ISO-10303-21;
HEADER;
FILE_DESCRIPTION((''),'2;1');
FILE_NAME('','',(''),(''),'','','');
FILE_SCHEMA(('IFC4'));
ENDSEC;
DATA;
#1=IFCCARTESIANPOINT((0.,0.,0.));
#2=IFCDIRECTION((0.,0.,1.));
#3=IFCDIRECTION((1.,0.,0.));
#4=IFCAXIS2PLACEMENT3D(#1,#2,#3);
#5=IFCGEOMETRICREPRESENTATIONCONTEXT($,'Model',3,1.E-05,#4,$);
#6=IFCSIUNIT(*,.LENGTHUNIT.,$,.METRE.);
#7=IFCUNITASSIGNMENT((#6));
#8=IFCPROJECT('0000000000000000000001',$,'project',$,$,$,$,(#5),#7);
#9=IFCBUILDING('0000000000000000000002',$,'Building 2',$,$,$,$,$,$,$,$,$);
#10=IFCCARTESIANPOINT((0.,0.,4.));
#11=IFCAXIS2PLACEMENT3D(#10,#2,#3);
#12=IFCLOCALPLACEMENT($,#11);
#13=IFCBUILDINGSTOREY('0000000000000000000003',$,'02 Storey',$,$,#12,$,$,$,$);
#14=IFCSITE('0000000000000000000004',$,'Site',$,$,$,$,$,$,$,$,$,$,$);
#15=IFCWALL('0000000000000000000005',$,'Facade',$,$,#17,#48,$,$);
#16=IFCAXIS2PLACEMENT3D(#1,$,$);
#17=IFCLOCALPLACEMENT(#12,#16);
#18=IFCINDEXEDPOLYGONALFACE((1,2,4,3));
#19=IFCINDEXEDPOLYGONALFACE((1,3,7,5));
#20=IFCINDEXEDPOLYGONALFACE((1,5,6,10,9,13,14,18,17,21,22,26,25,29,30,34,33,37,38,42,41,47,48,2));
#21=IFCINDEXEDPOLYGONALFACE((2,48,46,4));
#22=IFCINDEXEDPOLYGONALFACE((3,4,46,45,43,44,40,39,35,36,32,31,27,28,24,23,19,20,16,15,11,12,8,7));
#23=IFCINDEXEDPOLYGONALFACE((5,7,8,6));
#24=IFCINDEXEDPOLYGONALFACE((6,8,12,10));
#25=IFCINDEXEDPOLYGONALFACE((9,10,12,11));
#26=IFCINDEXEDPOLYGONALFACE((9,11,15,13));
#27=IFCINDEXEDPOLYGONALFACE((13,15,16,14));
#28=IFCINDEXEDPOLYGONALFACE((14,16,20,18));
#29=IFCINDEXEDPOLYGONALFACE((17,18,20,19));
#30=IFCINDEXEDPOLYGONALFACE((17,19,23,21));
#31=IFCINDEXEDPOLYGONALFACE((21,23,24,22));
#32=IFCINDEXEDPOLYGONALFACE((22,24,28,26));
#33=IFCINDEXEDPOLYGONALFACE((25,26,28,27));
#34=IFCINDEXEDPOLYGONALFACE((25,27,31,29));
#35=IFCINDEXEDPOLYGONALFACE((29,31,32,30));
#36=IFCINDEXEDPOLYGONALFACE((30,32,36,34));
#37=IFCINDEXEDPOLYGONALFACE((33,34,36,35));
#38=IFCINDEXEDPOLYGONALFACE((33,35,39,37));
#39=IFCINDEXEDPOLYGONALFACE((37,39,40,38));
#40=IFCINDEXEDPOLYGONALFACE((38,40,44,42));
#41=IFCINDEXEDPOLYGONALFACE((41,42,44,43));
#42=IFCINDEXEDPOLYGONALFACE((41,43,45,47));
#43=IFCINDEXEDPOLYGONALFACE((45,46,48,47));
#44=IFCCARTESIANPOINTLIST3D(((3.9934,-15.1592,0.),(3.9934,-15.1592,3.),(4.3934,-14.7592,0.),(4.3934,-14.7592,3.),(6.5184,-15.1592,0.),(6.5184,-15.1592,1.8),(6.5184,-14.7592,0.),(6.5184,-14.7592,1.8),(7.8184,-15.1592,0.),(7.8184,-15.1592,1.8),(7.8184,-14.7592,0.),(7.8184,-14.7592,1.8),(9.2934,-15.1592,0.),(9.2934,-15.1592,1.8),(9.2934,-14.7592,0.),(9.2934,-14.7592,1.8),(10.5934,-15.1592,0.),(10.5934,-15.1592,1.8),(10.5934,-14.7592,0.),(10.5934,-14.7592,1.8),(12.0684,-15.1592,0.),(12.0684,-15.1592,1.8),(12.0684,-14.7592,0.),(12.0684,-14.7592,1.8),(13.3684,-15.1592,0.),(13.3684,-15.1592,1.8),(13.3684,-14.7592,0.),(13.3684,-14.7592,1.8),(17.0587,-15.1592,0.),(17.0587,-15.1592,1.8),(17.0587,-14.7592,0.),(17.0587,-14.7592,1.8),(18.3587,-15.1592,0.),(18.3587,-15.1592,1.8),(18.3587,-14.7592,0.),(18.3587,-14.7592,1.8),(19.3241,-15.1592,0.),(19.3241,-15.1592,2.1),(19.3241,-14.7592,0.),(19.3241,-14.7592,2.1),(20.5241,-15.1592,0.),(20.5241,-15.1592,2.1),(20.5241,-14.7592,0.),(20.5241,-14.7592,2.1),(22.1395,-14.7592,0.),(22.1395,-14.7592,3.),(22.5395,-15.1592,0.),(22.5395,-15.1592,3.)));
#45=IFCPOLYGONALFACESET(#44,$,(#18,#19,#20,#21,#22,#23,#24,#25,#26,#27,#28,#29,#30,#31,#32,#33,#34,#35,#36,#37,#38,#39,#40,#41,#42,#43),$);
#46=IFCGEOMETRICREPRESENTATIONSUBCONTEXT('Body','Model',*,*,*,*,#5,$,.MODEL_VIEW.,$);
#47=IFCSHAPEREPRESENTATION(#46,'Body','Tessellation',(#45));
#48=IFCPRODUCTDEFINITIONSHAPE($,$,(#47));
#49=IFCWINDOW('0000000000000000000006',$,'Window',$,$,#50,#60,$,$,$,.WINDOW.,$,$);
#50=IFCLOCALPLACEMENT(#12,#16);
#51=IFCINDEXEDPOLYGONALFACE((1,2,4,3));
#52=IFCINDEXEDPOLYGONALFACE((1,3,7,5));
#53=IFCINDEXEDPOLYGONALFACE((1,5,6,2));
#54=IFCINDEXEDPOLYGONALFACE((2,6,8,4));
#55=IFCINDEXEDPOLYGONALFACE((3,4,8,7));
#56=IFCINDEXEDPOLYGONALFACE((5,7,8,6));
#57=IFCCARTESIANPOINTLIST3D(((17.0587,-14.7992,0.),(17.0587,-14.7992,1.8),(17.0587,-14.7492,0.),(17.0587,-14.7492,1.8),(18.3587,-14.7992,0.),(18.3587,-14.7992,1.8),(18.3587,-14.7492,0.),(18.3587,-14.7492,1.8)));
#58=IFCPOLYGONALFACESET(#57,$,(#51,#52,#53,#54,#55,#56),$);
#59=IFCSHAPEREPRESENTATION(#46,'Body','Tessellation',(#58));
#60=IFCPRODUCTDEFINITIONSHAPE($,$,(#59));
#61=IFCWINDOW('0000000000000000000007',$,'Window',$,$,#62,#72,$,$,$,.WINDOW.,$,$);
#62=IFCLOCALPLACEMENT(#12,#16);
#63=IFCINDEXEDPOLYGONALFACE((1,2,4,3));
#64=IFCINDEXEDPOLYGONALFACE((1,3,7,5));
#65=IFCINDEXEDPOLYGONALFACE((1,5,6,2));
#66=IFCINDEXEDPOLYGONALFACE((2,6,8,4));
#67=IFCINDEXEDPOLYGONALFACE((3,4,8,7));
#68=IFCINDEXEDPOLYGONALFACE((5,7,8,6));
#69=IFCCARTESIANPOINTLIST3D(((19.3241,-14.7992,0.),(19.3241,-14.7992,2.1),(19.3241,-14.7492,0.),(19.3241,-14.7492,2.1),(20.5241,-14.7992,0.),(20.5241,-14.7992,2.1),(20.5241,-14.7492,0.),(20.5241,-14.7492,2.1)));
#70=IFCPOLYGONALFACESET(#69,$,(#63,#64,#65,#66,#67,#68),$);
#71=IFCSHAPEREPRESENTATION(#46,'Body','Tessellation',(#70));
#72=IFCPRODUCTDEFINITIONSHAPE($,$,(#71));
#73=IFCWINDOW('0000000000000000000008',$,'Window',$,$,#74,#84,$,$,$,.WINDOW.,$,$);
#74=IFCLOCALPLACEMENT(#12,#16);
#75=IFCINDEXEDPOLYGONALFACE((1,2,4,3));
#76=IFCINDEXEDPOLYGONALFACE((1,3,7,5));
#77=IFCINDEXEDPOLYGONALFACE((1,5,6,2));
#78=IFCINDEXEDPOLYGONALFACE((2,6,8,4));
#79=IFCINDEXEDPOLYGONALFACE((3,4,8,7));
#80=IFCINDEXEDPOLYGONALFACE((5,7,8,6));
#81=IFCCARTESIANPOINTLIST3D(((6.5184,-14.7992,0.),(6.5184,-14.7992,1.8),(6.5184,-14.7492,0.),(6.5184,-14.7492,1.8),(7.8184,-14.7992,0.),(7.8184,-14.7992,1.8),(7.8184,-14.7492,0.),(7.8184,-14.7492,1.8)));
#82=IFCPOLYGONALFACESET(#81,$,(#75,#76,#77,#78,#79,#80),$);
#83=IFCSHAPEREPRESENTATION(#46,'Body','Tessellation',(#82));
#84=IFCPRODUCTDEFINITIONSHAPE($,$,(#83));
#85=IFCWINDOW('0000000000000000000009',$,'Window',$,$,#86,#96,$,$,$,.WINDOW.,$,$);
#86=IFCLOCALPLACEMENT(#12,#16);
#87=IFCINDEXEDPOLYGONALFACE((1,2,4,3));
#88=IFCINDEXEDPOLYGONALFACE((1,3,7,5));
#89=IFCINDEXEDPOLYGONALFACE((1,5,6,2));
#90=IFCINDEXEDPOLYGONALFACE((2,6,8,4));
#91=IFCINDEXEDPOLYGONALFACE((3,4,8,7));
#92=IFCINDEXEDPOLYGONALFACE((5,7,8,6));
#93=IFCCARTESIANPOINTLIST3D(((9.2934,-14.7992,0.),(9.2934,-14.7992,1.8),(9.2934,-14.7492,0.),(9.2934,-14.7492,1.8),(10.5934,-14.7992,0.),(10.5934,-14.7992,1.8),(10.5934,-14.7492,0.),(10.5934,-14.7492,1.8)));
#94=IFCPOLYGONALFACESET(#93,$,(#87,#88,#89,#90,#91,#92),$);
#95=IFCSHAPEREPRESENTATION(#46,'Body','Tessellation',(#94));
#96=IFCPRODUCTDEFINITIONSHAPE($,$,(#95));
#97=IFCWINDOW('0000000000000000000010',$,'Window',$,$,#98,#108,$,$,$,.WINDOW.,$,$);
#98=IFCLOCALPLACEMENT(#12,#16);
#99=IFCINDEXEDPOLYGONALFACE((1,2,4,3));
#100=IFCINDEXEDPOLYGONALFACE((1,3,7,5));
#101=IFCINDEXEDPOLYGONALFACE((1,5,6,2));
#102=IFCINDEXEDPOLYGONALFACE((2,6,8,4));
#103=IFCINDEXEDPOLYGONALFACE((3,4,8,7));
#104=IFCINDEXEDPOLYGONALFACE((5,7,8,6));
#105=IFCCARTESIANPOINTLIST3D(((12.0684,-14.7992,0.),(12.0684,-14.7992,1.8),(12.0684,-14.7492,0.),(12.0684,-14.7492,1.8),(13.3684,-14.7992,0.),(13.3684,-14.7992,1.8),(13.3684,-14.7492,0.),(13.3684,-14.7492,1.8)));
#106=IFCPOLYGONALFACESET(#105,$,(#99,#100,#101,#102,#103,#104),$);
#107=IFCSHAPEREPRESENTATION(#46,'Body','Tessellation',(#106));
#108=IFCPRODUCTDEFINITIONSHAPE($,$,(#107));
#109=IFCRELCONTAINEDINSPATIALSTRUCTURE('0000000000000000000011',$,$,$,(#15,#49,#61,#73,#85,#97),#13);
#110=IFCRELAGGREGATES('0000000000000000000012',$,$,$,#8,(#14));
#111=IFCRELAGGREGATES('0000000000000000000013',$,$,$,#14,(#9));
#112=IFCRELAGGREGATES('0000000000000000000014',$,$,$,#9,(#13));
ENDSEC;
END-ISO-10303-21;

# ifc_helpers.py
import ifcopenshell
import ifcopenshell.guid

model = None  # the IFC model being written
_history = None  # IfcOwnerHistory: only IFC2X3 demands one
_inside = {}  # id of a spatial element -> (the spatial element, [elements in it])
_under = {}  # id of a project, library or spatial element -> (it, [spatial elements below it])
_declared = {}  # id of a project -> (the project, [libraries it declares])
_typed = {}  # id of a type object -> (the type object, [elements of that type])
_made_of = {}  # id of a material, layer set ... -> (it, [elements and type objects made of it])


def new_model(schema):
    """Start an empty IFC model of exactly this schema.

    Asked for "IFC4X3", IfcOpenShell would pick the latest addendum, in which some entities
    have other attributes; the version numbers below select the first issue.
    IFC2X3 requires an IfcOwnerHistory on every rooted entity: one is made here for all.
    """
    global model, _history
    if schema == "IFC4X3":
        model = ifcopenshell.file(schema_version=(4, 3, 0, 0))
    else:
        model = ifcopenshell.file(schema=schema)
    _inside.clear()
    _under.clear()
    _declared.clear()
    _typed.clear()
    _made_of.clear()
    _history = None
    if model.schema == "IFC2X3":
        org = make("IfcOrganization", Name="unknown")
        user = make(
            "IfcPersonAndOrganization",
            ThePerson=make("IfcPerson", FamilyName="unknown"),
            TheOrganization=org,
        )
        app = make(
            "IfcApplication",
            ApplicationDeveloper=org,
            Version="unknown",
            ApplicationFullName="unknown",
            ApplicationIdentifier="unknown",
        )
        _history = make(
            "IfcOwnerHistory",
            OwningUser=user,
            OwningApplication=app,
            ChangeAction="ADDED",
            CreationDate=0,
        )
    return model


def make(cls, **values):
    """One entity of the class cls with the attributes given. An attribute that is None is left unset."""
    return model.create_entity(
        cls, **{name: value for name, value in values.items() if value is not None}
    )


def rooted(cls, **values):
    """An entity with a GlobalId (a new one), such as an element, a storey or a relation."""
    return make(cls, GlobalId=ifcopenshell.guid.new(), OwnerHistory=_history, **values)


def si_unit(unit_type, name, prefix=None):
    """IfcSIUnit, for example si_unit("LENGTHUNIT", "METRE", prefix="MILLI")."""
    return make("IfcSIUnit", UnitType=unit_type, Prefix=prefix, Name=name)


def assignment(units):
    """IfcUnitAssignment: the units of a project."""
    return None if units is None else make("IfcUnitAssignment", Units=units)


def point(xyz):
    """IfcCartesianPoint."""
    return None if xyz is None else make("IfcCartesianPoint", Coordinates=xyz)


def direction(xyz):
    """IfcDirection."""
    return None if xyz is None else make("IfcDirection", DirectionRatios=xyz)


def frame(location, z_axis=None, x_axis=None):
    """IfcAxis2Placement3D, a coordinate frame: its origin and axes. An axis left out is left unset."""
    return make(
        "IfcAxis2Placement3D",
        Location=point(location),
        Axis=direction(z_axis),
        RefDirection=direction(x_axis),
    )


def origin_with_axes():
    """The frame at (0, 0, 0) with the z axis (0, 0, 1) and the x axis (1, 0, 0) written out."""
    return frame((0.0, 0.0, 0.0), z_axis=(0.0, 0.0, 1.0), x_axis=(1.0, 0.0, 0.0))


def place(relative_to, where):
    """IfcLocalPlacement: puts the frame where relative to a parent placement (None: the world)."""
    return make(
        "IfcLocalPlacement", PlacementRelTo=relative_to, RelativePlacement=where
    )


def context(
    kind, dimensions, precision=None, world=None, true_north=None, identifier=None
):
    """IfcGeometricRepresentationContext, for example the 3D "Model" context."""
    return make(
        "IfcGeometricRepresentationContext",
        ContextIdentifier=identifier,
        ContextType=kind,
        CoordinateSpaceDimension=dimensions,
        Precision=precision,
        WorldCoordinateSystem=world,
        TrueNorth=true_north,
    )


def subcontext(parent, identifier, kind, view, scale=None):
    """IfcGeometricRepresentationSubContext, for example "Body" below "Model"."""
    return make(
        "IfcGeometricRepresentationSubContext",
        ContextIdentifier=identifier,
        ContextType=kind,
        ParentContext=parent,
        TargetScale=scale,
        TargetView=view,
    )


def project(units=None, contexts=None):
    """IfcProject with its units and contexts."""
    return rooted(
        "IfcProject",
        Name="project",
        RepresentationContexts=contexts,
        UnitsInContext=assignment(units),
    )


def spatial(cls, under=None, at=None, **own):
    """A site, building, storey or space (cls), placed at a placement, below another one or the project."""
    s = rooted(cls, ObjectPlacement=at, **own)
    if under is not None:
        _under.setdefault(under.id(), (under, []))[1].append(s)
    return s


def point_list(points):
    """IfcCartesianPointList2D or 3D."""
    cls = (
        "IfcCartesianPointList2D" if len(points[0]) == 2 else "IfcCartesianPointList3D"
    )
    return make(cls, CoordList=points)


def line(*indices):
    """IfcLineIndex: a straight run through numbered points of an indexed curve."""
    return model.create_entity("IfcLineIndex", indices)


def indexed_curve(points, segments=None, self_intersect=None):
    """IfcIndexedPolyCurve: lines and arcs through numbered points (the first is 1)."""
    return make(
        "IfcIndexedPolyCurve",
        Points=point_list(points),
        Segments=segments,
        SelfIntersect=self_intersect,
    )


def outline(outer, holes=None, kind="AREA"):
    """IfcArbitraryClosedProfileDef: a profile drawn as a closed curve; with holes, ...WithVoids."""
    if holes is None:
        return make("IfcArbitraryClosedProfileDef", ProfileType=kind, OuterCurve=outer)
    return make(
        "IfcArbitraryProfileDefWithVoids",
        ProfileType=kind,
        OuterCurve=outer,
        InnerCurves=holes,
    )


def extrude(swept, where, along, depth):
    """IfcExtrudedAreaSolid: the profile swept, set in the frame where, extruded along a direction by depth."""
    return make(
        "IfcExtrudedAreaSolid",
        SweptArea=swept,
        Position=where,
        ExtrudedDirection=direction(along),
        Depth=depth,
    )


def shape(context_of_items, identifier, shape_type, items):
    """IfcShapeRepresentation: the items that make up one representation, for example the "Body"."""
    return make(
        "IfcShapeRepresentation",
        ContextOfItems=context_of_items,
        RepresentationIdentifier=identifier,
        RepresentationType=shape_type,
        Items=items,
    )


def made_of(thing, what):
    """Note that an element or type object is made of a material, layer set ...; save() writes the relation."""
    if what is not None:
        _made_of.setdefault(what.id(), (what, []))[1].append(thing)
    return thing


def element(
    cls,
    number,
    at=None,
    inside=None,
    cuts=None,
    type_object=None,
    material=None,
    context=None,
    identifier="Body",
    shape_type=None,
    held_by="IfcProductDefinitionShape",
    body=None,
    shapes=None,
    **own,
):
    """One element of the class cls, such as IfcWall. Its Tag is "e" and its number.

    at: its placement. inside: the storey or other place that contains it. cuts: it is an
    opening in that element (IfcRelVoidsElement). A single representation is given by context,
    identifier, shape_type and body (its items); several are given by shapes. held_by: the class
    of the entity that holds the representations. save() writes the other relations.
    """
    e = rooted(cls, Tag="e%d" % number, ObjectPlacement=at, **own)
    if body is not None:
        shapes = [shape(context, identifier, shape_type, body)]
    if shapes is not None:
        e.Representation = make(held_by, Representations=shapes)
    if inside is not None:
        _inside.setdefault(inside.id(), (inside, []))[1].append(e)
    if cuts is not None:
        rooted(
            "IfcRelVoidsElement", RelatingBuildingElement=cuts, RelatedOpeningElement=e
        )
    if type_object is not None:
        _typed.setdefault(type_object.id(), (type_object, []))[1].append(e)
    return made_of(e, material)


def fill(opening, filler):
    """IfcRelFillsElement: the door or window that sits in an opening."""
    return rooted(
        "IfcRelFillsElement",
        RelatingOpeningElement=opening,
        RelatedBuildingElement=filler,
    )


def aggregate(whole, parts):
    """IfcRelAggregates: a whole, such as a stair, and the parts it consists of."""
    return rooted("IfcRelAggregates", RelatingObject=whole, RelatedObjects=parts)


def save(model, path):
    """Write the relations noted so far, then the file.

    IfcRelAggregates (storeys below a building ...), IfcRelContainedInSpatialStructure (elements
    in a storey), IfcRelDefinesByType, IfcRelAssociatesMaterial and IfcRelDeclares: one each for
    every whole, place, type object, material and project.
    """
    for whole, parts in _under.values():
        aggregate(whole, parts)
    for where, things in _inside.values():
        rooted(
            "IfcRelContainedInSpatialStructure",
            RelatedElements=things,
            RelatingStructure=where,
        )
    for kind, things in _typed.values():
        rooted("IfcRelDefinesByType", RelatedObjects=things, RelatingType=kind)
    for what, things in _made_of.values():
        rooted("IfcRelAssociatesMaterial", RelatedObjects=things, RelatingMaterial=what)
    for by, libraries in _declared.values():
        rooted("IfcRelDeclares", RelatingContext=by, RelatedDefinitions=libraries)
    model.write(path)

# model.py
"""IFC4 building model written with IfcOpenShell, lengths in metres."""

from ifc_helpers import new_model, si_unit, frame, origin_with_axes, place, context, subcontext, project, spatial, line, indexed_curve, outline, extrude, element, fill, save


model = new_model("IFC4")

# Units and contexts
model_context = context("Model", 3, precision=1e-05, world=origin_with_axes())
body_context = subcontext(model_context, "Body", "Model", "MODEL_VIEW")
ifc_project = project(units=[si_unit("LENGTHUNIT", "METRE")], contexts=[model_context])

# Site, building, storey
site = spatial("IfcSite", under=ifc_project, Name="Site")
building = spatial("IfcBuilding", under=site, Name="Building 2")
storey_placement = place(None, frame((0.0, 0.0, 4.0), z_axis=(0.0, 0.0, 1.0), x_axis=(1.0, 0.0, 0.0)))
storey = spatial("IfcBuildingStorey", under=building, at=storey_placement, Name="02 Storey")

# Wall, openings, windows
wall_1_placement = place(storey_placement, origin_with_axes())
wall_1 = element("IfcWall", 1, at=wall_1_placement, inside=storey, Name="Facade", context=body_context, shape_type="SweptSolid", body=[
    extrude(outline(indexed_curve([(4.3934, -14.7592), (22.1395, -14.7592), (22.5395, -15.1592), (3.9934, -15.1592)], segments=[line(1, 2), line(2, 3), line(3, 4)])), origin_with_axes(), (0.0, 0.0, 1.0), 3.0),
])
opening_1_placement = place(wall_1_placement, origin_with_axes())
opening_1 = element("IfcOpeningElement", 2, at=opening_1_placement, cuts=wall_1, context=body_context, shape_type="SweptSolid", body=[
    extrude(outline(indexed_curve([(17.0587, -15.1992), (17.0587, -14.6992), (18.3587, -14.6992), (18.3587, -15.1992)], segments=[line(1, 2), line(2, 3), line(3, 4)])), origin_with_axes(), (0.0, 0.0, 1.0), 1.8),
])
opening_2_placement = place(wall_1_placement, origin_with_axes())
opening_2 = element("IfcOpeningElement", 3, at=opening_2_placement, cuts=wall_1, context=body_context, shape_type="SweptSolid", body=[
    extrude(outline(indexed_curve([(19.3241, -15.1992), (19.3241, -14.6992), (20.5241, -14.6992), (20.5241, -15.1992)], segments=[line(1, 2), line(2, 3), line(3, 4)])), origin_with_axes(), (0.0, 0.0, 1.0), 2.1),
])
opening_3_placement = place(wall_1_placement, origin_with_axes())
opening_3 = element("IfcOpeningElement", 4, at=opening_3_placement, cuts=wall_1, context=body_context, shape_type="SweptSolid", body=[
    extrude(outline(indexed_curve([(6.5184, -15.1992), (6.5184, -14.6992), (7.8184, -14.6992), (7.8184, -15.1992)], segments=[line(1, 2), line(2, 3), line(3, 4)])), origin_with_axes(), (0.0, 0.0, 1.0), 1.8),
])
opening_4_placement = place(wall_1_placement, origin_with_axes())
opening_4 = element("IfcOpeningElement", 5, at=opening_4_placement, cuts=wall_1, context=body_context, shape_type="SweptSolid", body=[
    extrude(outline(indexed_curve([(9.2934, -15.1992), (9.2934, -14.6992), (10.5934, -14.6992), (10.5934, -15.1992)], segments=[line(1, 2), line(2, 3), line(3, 4)])), origin_with_axes(), (0.0, 0.0, 1.0), 1.8),
])
opening_5_placement = place(wall_1_placement, origin_with_axes())
opening_5 = element("IfcOpeningElement", 6, at=opening_5_placement, cuts=wall_1, context=body_context, shape_type="SweptSolid", body=[
    extrude(outline(indexed_curve([(12.0684, -15.1992), (12.0684, -14.6992), (13.3684, -14.6992), (13.3684, -15.1992)], segments=[line(1, 2), line(2, 3), line(3, 4)])), origin_with_axes(), (0.0, 0.0, 1.0), 1.8),
])
window_1_placement = place(storey_placement, origin_with_axes())
window_1 = element("IfcWindow", 7, at=window_1_placement, inside=storey, Name="Window", PredefinedType="WINDOW", context=body_context, shape_type="SweptSolid", body=[
    extrude(outline(indexed_curve([(17.0587, -14.7992), (17.0587, -14.7492), (18.3587, -14.7492), (18.3587, -14.7992)], segments=[line(1, 2), line(2, 3), line(3, 4)])), origin_with_axes(), (0.0, 0.0, 1.0), 1.8),
])
fill(opening_1, window_1)
window_2_placement = place(storey_placement, origin_with_axes())
window_2 = element("IfcWindow", 8, at=window_2_placement, inside=storey, Name="Window", PredefinedType="WINDOW", context=body_context, shape_type="SweptSolid", body=[
    extrude(outline(indexed_curve([(19.3241, -14.7992), (19.3241, -14.7492), (20.5241, -14.7492), (20.5241, -14.7992)], segments=[line(1, 2), line(2, 3), line(3, 4)])), origin_with_axes(), (0.0, 0.0, 1.0), 2.1),
])
fill(opening_2, window_2)
window_3_placement = place(storey_placement, origin_with_axes())
window_3 = element("IfcWindow", 9, at=window_3_placement, inside=storey, Name="Window", PredefinedType="WINDOW", context=body_context, shape_type="SweptSolid", body=[
    extrude(outline(indexed_curve([(6.5184, -14.7992), (6.5184, -14.7492), (7.8184, -14.7492), (7.8184, -14.7992)], segments=[line(1, 2), line(2, 3), line(3, 4)])), origin_with_axes(), (0.0, 0.0, 1.0), 1.8),
])
fill(opening_3, window_3)
window_4_placement = place(storey_placement, origin_with_axes())
window_4 = element("IfcWindow", 10, at=window_4_placement, inside=storey, Name="Window", PredefinedType="WINDOW", context=body_context, shape_type="SweptSolid", body=[
    extrude(outline(indexed_curve([(9.2934, -14.7992), (9.2934, -14.7492), (10.5934, -14.7492), (10.5934, -14.7992)], segments=[line(1, 2), line(2, 3), line(3, 4)])), origin_with_axes(), (0.0, 0.0, 1.0), 1.8),
])
fill(opening_4, window_4)
window_5_placement = place(storey_placement, origin_with_axes())
window_5 = element("IfcWindow", 11, at=window_5_placement, inside=storey, Name="Window", PredefinedType="WINDOW", context=body_context, shape_type="SweptSolid", body=[
    extrude(outline(indexed_curve([(12.0684, -14.7992), (12.0684, -14.7492), (13.3684, -14.7492), (13.3684, -14.7992)], segments=[line(1, 2), line(2, 3), line(3, 4)])), origin_with_axes(), (0.0, 0.0, 1.0), 1.8),
])
fill(opening_5, window_5)

save(model, "model.ifc")
